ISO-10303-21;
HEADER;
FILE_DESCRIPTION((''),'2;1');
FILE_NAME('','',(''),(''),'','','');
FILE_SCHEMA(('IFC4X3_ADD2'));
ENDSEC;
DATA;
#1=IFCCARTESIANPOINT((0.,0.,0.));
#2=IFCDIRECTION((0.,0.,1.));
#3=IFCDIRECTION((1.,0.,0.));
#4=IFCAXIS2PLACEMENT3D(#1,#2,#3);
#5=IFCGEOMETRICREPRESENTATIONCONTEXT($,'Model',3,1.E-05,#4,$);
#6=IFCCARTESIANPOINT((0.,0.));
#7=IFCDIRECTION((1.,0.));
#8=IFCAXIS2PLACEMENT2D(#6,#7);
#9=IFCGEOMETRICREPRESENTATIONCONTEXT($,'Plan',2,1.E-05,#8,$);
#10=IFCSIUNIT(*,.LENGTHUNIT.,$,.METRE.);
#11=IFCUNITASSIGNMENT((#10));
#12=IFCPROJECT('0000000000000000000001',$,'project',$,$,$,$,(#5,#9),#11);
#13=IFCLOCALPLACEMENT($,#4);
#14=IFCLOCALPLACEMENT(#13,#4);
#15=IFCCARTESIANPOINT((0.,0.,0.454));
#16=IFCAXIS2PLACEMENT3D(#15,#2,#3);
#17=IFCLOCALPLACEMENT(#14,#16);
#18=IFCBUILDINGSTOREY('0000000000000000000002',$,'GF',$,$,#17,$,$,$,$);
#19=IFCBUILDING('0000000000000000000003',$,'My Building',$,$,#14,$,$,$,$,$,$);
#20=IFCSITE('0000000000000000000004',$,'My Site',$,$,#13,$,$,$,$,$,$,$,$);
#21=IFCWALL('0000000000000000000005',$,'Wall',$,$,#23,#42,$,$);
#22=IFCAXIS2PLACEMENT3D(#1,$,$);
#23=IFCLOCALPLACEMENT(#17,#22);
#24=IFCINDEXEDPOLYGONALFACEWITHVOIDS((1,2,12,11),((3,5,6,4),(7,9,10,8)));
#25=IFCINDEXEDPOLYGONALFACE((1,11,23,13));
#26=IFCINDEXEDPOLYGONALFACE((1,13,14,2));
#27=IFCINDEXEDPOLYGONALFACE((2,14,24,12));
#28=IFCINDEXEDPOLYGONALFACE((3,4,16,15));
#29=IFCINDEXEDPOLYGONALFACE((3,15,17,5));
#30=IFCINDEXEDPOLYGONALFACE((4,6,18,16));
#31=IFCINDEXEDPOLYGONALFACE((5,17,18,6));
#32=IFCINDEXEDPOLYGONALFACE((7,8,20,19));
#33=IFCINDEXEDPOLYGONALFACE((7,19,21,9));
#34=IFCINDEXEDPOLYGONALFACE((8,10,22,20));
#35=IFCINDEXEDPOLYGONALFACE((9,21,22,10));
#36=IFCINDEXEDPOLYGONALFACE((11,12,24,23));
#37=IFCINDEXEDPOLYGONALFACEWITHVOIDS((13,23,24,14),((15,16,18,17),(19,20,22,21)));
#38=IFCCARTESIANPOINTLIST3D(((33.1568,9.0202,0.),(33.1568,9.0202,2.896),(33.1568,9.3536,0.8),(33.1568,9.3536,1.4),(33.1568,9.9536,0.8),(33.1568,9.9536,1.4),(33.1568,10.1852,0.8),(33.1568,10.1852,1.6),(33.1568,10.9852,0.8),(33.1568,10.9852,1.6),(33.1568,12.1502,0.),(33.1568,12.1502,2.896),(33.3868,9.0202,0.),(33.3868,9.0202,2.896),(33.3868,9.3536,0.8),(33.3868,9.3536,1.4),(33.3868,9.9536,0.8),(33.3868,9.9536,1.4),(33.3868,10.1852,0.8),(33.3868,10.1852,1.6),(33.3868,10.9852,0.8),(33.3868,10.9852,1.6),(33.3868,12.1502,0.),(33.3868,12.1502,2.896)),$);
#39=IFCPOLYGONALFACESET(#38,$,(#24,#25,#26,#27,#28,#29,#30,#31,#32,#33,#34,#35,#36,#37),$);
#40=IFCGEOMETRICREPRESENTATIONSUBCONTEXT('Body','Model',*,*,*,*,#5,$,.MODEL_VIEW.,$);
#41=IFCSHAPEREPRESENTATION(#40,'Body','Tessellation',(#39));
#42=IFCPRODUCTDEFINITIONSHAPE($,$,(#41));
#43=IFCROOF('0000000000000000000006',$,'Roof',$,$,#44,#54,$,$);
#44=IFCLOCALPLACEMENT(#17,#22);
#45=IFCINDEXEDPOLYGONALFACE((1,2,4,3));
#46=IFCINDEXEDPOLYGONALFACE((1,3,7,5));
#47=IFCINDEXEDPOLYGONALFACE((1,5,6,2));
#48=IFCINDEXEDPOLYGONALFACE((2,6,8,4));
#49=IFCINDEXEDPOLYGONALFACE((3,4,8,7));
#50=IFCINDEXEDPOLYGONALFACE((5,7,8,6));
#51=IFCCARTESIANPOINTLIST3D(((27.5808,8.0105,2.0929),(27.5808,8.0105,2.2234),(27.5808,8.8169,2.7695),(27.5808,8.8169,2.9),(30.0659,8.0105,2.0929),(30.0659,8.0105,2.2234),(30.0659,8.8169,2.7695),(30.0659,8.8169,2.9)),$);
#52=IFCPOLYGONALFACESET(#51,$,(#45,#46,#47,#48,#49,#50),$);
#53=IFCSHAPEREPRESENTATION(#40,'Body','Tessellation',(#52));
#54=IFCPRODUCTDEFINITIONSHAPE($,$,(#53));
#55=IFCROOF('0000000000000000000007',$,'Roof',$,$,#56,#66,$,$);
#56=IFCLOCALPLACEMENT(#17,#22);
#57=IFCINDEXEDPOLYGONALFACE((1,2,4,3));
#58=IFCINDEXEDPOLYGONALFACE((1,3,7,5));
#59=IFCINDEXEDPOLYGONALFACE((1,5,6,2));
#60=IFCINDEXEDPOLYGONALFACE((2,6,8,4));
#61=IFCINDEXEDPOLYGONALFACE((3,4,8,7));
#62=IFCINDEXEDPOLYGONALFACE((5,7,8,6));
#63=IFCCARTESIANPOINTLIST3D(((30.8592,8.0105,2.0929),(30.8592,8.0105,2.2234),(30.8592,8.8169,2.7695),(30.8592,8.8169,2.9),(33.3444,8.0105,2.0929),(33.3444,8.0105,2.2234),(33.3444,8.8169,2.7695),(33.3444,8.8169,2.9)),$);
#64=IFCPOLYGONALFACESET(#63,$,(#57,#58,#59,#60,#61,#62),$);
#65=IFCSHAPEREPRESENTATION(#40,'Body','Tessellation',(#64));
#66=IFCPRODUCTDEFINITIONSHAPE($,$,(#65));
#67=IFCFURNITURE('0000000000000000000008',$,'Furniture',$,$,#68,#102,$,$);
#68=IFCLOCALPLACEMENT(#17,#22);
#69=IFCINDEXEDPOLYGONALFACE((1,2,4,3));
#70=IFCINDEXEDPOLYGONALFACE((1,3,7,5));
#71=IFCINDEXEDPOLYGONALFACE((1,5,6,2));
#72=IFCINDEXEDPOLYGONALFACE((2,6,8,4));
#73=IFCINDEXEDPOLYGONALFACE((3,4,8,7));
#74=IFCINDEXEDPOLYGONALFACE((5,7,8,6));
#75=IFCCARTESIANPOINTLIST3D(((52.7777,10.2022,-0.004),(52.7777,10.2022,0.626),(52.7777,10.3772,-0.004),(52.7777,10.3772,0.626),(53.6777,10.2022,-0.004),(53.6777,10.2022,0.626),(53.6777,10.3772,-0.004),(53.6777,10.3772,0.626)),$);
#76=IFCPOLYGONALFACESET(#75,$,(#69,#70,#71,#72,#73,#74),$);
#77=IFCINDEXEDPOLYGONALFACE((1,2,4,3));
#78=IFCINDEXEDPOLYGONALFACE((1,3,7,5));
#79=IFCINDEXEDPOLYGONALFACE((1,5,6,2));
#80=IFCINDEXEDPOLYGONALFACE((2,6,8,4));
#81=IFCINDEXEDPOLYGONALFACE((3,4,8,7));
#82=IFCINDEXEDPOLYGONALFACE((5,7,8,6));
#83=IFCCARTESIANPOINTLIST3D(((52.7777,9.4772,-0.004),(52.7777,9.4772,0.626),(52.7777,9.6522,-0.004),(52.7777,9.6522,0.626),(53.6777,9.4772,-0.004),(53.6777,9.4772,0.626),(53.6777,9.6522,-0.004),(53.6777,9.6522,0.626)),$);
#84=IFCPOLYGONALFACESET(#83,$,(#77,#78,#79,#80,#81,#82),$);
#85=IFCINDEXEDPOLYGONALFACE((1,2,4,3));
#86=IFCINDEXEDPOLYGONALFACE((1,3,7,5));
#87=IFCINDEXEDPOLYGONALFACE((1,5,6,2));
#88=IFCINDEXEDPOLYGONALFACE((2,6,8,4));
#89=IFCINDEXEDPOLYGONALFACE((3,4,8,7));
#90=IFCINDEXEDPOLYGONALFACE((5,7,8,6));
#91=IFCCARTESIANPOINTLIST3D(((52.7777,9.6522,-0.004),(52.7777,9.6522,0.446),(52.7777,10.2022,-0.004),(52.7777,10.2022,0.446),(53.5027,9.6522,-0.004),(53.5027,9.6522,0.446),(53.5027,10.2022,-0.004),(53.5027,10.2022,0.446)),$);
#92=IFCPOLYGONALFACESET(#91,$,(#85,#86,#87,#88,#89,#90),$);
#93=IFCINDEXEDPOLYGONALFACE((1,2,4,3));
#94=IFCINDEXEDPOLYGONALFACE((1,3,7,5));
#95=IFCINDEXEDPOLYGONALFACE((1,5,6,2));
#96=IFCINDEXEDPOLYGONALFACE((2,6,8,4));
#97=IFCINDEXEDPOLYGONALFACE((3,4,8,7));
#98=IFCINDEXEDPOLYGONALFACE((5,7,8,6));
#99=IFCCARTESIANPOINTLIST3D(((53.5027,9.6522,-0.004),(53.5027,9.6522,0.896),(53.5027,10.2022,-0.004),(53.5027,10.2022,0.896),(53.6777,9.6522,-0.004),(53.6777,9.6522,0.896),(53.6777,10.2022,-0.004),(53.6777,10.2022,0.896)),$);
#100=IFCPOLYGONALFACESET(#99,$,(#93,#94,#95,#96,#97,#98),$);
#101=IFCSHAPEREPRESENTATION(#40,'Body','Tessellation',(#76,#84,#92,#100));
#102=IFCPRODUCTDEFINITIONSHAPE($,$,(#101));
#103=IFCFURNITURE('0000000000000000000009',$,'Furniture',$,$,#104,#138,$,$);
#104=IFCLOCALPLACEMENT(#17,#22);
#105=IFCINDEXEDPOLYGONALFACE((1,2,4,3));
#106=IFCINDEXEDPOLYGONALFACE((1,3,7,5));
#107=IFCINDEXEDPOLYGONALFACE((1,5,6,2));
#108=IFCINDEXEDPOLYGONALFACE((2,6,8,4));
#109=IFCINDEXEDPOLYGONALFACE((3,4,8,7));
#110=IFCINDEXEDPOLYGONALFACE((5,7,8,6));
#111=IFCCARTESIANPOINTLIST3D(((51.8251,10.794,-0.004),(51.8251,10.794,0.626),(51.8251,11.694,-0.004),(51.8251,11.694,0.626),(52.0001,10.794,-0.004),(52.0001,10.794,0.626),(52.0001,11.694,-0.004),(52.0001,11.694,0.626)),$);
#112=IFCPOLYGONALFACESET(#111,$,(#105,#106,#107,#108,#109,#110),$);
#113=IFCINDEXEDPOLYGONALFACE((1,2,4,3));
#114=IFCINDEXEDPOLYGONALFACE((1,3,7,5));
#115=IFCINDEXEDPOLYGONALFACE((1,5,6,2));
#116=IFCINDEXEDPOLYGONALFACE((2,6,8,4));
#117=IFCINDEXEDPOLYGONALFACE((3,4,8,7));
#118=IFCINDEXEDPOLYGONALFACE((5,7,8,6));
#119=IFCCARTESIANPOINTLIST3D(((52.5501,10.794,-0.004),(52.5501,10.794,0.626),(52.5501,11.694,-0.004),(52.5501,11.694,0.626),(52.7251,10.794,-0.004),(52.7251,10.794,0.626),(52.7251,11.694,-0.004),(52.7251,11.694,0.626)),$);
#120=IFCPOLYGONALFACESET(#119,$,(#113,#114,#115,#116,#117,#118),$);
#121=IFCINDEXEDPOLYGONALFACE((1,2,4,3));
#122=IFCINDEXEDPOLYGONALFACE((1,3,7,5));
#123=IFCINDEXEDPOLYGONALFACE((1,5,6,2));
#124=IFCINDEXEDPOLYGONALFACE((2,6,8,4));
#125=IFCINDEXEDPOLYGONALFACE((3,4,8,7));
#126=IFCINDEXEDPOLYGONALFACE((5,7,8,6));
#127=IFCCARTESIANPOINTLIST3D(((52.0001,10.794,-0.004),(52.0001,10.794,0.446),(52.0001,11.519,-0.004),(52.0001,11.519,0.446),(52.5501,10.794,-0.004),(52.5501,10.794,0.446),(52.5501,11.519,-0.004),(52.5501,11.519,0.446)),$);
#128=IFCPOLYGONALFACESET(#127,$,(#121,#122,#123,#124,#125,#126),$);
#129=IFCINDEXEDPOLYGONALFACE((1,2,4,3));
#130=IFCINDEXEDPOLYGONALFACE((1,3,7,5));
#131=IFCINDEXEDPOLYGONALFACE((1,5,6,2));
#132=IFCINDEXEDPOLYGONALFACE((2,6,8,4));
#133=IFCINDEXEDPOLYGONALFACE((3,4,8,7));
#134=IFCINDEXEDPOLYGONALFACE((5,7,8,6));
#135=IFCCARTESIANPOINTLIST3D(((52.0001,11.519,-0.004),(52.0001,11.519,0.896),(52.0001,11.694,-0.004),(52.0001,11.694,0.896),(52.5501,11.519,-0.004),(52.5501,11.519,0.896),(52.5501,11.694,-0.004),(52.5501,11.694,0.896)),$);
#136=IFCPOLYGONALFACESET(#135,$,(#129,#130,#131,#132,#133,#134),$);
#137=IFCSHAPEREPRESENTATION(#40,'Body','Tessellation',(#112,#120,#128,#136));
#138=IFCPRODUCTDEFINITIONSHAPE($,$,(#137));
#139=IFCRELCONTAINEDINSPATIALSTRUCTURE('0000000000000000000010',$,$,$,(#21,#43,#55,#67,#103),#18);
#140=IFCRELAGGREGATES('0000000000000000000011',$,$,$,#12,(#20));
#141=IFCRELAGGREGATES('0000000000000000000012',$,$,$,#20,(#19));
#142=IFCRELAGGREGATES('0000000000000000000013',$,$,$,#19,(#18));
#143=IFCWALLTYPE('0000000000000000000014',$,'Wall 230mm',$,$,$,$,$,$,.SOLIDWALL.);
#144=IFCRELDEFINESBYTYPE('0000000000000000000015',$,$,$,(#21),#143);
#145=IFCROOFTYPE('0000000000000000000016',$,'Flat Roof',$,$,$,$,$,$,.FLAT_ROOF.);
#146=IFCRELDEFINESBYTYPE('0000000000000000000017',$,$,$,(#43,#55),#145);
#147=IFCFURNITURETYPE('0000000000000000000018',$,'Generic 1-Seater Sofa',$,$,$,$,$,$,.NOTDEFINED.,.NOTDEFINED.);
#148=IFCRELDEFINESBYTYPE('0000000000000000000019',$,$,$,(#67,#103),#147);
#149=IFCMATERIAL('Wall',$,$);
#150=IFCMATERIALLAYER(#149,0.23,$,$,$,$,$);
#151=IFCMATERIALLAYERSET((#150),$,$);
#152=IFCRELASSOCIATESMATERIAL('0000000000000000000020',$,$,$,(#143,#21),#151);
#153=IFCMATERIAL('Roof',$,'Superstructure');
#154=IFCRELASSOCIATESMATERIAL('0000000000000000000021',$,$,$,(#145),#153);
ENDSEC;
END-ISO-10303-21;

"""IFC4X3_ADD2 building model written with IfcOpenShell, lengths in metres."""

from ifc_helpers import new_model, entity, si_unit, frame, origin_with_axes, origin_2d_with_axis, place, context, subcontext, project, spatial, polyline, line, indexed_curve, outline, extrude, clip, halfspace, shape, source, transform, mapped, material, layer, layer_set, layer_usage, type_object, type_shapes, element, save


model = new_model("IFC4X3_ADD2")

# Units and contexts
model_context = context("Model", 3, precision=1e-05, world=origin_with_axes())
plan_context = context("Plan", 2, precision=1e-05, world=origin_2d_with_axis())
body_context_1 = subcontext(model_context, "Body", "Model", "MODEL_VIEW")
body_context_2 = subcontext(plan_context, "Body", "Plan", "PLAN_VIEW")
ifc_project = project(units=[si_unit("LENGTHUNIT", "METRE")], contexts=[model_context, plan_context])

# Site, building, storey
site_placement = place(None, origin_with_axes())
site = spatial("IfcSite", under=ifc_project, at=site_placement, Name="My Site")
building_placement = place(site_placement, origin_with_axes())
building = spatial("IfcBuilding", under=site, at=building_placement, Name="My Building")
storey_placement = place(building_placement, frame((0.0, 0.0, 0.454), z_axis=(0.0, 0.0, 1.0), x_axis=(1.0, 0.0, 0.0)))
storey = spatial("IfcBuildingStorey", under=building, at=storey_placement, Name="GF")

# Shared definitions
ifc_material_1 = material(Name="Wall")

# Shared definitions
ifc_layer_1 = layer(ifc_material_1, 0.23)
ifc_layer_set_1 = layer_set([ifc_layer_1])
wall_type_1 = type_object("IfcWallType", Name="Wall 230mm", PredefinedType="SOLIDWALL", material=ifc_layer_set_1)

# Wall, openings
ifc_layer_usage_1 = layer_usage(ifc_layer_set_1, "AXIS2", "POSITIVE", 0.0)
wall_1_placement = place(storey_placement, frame((33.3868, 9.0202, 0.0), z_axis=(0.0, 0.0, 1.0), x_axis=(0.000001, 1.0, 0.0)))
wall_1 = element("IfcWall", 1, at=wall_1_placement, inside=storey, type_object=wall_type_1, material=ifc_layer_usage_1, Name="Wall", context=body_context_1, shape_type="Clipping", body=[
    clip(extrude(outline(indexed_curve([(0.0, 0.0), (0.0, 0.23), (3.13, 0.23), (3.13, 0.0), (0.0, 0.0)], self_intersect=False)), origin_with_axes(), (0.0, 0.0, 1.0), 3.35), halfspace(frame((0.0, 0.0, 2.896), z_axis=(0.0, 0.0, 1.0), x_axis=(-1.0, 0.0, 0.0)), False)),
])
shared_shape_1 = source(origin_with_axes(), body_context_1, "Body", "SweptSolid", [
    extrude(outline(indexed_curve([(0.0, 0.0), (0.6, 0.0), (0.6, 0.6), (0.0, 0.6)], segments=[line(1, 2, 3, 4, 1)])), frame((-0.3, -0.6, 0.0), z_axis=(0.0, -1.0, 0.0), x_axis=(1.0, 0.0, 0.0)), (0.0, 0.0, -1.0), 1.2),
])
opening_1_placement = place(wall_1_placement, frame((0.6334, 0.0, 0.8), z_axis=(0.0, 0.0, 1.0), x_axis=(1.0, 0.0, 0.0)))
element("IfcOpeningElement", 2, at=opening_1_placement, cuts=wall_1, PredefinedType="OPENING", context=body_context_1, shape_type="MappedRepresentation", body=[
    mapped(shared_shape_1, transform((0.0, 0.0, 0.0), x_axis=(1.0, 0.0, 0.0), y_axis=(0.0, 1.0, 0.0), z_axis=(0.0, 0.0, 1.0), scale=1.0)),
])
shared_shape_2 = source(origin_with_axes(), body_context_1, "Body", "SweptSolid", [
    extrude(outline(indexed_curve([(0.0, 0.0), (0.8, 0.0), (0.8, 0.8), (0.0, 0.8)], segments=[line(1, 2, 3, 4, 1)])), frame((-0.4, -0.6, 0.0), z_axis=(0.0, -1.0, 0.0), x_axis=(1.0, 0.0, 0.0)), (0.0, 0.0, -1.0), 1.2),
])
opening_2_placement = place(wall_1_placement, frame((1.565, 0.0, 0.8), z_axis=(0.0, 0.0, 1.0), x_axis=(1.0, 0.0, 0.0)))
element("IfcOpeningElement", 3, at=opening_2_placement, cuts=wall_1, PredefinedType="OPENING", context=body_context_1, shape_type="MappedRepresentation", body=[
    mapped(shared_shape_2, transform((0.0, 0.0, 0.0), x_axis=(1.0, 0.0, 0.0), y_axis=(0.0, 1.0, 0.0), z_axis=(0.0, 0.0, 1.0), scale=1.0)),
])

# Roofs
ifc_material_2 = material(Name="Roof", Category="Superstructure")
roof_type = type_object("IfcRoofType", Name="Flat Roof", PredefinedType="FLAT_ROOF", material=ifc_material_2)
for number, where, z_axis, x_axis, name in (
    (4, (27.5808, 8.0241, 2.1043), (0.0, -0.642788, 0.766044), (1.0, 0.0, 0.0), "Roof"),
    (5, (30.8592, 8.0241, 2.1043), (0.0, -0.642788, 0.766044), (1.0, 0.0, 0.0), "Roof"),
):
    element("IfcRoof", number, at=place(storey_placement, frame(where, z_axis=z_axis, x_axis=x_axis)), inside=storey, type_object=roof_type, Name=name, context=body_context_1, shape_type="SweptSolid", body=[
        extrude(outline(polyline([(-1.2426, -0.0653), (1.2426, -0.0653), (1.2426, 0.0653), (-1.2426, 0.0653), (-1.2426, -0.0653)])), frame((1.2426, 1.0768, 0.05), z_axis=(0.0, 0.766044, -0.642788), x_axis=(1.0, 0.0, 0.0)), (0.0, 0.642788, -0.766044), 1.0526),
    ])

# Furniture
furniture_type_1 = type_object("IfcFurnitureType", Name="Generic 1-Seater Sofa", AssemblyPlace="NOTDEFINED", PredefinedType="NOTDEFINED")
shared_shape_3 = source(origin_with_axes(), body_context_1, "Body", "SweptSolid", [
    extrude(outline(indexed_curve([(0.0, 0.0), (0.175, 0.0), (0.175, 0.9), (0.0, 0.9)], segments=[line(4, 1), line(1, 2), line(2, 3), line(3, 4)], self_intersect=False)), frame((-0.45, -0.9, 0.0), z_axis=(0.0, 0.0, 1.0), x_axis=(1.0, 0.0, 0.0)), (0.0, 0.0, 1.0), 0.63),
    extrude(outline(indexed_curve([(0.0, 0.0), (0.175, 0.0), (0.175, 0.9), (0.0, 0.9)], segments=[line(1, 2, 3, 4, 1)])), frame((0.275, -0.9, 0.0), z_axis=(0.0, 0.0, 1.0), x_axis=(1.0, 0.0, 0.0)), (0.0, 0.0, 1.0), 0.63),
    extrude(outline(indexed_curve([(0.175, 0.0), (0.725, 0.0), (0.725, 0.725), (0.175, 0.725)], segments=[line(1, 2, 3, 4, 1)])), frame((-0.45, -0.9, 0.0), z_axis=(0.0, 0.0, 1.0), x_axis=(1.0, 0.0, 0.0)), (0.0, 0.0, 1.0), 0.45),
    extrude(outline(indexed_curve([(0.175, 0.725), (0.725, 0.725), (0.725, 0.9), (0.175, 0.9)], segments=[line(1, 2, 3, 4, 1)])), frame((-0.45, -0.9, 0.0), z_axis=(0.0, 0.0, 1.0), x_axis=(1.0, 0.0, 0.0)), (0.0, 0.0, 1.0), 0.9),
])
shared_shape_4 = source(origin_with_axes(), body_context_2, "Body", "Annotation2D", [
    entity("IfcGeometricCurveSet", [entity("IfcIndexedPolyCurve", entity("IfcCartesianPointList2D", [[0.275, -0.175], [0.275, -0.9], [0.45, -0.9], [0.45, 0.0], [0.275, 0.0], [0.275, -0.9], [-0.275, -0.9], [-0.275, 0.0], [-0.275, -0.175], [0.275, -0.175], [0.275, 0.0], [-0.275, 0.0], [-0.45, 0.0], [-0.45, -0.9], [-0.275, -0.9], [-0.275, -0.175]]))]),
])
type_shapes(furniture_type_1, [shared_shape_3, shared_shape_4])
for number, where, z_axis, x_axis, name in (
    (6, (53.6777, 9.9272, -0.004), (0.0, 0.0, 1.0), (0.0, -1.0, 0.0), "Furniture"),
    (7, (52.2751, 11.694, -0.004), (0.0, 0.0, 1.0), (1.0, 0.0, 0.0), "Furniture"),
):
    element("IfcFurniture", number, at=place(storey_placement, frame(where, z_axis=z_axis, x_axis=x_axis)), inside=storey, type_object=furniture_type_1, Name=name, shapes=[
        shape(body_context_1, "Body", "MappedRepresentation", [mapped(shared_shape_3, transform((0.0, 0.0, 0.0), x_axis=(1.0, 0.0, 0.0), y_axis=(0.0, 1.0, 0.0), z_axis=(0.0, 0.0, 1.0), scale=1.0))]),
        shape(body_context_2, "Body", "MappedRepresentation", [mapped(shared_shape_4, transform((0.0, 0.0, 0.0), x_axis=(1.0, 0.0, 0.0), y_axis=(0.0, 1.0, 0.0), z_axis=(0.0, 0.0, 1.0), scale=1.0))]),
    ])

save(model, "model.ifc")
